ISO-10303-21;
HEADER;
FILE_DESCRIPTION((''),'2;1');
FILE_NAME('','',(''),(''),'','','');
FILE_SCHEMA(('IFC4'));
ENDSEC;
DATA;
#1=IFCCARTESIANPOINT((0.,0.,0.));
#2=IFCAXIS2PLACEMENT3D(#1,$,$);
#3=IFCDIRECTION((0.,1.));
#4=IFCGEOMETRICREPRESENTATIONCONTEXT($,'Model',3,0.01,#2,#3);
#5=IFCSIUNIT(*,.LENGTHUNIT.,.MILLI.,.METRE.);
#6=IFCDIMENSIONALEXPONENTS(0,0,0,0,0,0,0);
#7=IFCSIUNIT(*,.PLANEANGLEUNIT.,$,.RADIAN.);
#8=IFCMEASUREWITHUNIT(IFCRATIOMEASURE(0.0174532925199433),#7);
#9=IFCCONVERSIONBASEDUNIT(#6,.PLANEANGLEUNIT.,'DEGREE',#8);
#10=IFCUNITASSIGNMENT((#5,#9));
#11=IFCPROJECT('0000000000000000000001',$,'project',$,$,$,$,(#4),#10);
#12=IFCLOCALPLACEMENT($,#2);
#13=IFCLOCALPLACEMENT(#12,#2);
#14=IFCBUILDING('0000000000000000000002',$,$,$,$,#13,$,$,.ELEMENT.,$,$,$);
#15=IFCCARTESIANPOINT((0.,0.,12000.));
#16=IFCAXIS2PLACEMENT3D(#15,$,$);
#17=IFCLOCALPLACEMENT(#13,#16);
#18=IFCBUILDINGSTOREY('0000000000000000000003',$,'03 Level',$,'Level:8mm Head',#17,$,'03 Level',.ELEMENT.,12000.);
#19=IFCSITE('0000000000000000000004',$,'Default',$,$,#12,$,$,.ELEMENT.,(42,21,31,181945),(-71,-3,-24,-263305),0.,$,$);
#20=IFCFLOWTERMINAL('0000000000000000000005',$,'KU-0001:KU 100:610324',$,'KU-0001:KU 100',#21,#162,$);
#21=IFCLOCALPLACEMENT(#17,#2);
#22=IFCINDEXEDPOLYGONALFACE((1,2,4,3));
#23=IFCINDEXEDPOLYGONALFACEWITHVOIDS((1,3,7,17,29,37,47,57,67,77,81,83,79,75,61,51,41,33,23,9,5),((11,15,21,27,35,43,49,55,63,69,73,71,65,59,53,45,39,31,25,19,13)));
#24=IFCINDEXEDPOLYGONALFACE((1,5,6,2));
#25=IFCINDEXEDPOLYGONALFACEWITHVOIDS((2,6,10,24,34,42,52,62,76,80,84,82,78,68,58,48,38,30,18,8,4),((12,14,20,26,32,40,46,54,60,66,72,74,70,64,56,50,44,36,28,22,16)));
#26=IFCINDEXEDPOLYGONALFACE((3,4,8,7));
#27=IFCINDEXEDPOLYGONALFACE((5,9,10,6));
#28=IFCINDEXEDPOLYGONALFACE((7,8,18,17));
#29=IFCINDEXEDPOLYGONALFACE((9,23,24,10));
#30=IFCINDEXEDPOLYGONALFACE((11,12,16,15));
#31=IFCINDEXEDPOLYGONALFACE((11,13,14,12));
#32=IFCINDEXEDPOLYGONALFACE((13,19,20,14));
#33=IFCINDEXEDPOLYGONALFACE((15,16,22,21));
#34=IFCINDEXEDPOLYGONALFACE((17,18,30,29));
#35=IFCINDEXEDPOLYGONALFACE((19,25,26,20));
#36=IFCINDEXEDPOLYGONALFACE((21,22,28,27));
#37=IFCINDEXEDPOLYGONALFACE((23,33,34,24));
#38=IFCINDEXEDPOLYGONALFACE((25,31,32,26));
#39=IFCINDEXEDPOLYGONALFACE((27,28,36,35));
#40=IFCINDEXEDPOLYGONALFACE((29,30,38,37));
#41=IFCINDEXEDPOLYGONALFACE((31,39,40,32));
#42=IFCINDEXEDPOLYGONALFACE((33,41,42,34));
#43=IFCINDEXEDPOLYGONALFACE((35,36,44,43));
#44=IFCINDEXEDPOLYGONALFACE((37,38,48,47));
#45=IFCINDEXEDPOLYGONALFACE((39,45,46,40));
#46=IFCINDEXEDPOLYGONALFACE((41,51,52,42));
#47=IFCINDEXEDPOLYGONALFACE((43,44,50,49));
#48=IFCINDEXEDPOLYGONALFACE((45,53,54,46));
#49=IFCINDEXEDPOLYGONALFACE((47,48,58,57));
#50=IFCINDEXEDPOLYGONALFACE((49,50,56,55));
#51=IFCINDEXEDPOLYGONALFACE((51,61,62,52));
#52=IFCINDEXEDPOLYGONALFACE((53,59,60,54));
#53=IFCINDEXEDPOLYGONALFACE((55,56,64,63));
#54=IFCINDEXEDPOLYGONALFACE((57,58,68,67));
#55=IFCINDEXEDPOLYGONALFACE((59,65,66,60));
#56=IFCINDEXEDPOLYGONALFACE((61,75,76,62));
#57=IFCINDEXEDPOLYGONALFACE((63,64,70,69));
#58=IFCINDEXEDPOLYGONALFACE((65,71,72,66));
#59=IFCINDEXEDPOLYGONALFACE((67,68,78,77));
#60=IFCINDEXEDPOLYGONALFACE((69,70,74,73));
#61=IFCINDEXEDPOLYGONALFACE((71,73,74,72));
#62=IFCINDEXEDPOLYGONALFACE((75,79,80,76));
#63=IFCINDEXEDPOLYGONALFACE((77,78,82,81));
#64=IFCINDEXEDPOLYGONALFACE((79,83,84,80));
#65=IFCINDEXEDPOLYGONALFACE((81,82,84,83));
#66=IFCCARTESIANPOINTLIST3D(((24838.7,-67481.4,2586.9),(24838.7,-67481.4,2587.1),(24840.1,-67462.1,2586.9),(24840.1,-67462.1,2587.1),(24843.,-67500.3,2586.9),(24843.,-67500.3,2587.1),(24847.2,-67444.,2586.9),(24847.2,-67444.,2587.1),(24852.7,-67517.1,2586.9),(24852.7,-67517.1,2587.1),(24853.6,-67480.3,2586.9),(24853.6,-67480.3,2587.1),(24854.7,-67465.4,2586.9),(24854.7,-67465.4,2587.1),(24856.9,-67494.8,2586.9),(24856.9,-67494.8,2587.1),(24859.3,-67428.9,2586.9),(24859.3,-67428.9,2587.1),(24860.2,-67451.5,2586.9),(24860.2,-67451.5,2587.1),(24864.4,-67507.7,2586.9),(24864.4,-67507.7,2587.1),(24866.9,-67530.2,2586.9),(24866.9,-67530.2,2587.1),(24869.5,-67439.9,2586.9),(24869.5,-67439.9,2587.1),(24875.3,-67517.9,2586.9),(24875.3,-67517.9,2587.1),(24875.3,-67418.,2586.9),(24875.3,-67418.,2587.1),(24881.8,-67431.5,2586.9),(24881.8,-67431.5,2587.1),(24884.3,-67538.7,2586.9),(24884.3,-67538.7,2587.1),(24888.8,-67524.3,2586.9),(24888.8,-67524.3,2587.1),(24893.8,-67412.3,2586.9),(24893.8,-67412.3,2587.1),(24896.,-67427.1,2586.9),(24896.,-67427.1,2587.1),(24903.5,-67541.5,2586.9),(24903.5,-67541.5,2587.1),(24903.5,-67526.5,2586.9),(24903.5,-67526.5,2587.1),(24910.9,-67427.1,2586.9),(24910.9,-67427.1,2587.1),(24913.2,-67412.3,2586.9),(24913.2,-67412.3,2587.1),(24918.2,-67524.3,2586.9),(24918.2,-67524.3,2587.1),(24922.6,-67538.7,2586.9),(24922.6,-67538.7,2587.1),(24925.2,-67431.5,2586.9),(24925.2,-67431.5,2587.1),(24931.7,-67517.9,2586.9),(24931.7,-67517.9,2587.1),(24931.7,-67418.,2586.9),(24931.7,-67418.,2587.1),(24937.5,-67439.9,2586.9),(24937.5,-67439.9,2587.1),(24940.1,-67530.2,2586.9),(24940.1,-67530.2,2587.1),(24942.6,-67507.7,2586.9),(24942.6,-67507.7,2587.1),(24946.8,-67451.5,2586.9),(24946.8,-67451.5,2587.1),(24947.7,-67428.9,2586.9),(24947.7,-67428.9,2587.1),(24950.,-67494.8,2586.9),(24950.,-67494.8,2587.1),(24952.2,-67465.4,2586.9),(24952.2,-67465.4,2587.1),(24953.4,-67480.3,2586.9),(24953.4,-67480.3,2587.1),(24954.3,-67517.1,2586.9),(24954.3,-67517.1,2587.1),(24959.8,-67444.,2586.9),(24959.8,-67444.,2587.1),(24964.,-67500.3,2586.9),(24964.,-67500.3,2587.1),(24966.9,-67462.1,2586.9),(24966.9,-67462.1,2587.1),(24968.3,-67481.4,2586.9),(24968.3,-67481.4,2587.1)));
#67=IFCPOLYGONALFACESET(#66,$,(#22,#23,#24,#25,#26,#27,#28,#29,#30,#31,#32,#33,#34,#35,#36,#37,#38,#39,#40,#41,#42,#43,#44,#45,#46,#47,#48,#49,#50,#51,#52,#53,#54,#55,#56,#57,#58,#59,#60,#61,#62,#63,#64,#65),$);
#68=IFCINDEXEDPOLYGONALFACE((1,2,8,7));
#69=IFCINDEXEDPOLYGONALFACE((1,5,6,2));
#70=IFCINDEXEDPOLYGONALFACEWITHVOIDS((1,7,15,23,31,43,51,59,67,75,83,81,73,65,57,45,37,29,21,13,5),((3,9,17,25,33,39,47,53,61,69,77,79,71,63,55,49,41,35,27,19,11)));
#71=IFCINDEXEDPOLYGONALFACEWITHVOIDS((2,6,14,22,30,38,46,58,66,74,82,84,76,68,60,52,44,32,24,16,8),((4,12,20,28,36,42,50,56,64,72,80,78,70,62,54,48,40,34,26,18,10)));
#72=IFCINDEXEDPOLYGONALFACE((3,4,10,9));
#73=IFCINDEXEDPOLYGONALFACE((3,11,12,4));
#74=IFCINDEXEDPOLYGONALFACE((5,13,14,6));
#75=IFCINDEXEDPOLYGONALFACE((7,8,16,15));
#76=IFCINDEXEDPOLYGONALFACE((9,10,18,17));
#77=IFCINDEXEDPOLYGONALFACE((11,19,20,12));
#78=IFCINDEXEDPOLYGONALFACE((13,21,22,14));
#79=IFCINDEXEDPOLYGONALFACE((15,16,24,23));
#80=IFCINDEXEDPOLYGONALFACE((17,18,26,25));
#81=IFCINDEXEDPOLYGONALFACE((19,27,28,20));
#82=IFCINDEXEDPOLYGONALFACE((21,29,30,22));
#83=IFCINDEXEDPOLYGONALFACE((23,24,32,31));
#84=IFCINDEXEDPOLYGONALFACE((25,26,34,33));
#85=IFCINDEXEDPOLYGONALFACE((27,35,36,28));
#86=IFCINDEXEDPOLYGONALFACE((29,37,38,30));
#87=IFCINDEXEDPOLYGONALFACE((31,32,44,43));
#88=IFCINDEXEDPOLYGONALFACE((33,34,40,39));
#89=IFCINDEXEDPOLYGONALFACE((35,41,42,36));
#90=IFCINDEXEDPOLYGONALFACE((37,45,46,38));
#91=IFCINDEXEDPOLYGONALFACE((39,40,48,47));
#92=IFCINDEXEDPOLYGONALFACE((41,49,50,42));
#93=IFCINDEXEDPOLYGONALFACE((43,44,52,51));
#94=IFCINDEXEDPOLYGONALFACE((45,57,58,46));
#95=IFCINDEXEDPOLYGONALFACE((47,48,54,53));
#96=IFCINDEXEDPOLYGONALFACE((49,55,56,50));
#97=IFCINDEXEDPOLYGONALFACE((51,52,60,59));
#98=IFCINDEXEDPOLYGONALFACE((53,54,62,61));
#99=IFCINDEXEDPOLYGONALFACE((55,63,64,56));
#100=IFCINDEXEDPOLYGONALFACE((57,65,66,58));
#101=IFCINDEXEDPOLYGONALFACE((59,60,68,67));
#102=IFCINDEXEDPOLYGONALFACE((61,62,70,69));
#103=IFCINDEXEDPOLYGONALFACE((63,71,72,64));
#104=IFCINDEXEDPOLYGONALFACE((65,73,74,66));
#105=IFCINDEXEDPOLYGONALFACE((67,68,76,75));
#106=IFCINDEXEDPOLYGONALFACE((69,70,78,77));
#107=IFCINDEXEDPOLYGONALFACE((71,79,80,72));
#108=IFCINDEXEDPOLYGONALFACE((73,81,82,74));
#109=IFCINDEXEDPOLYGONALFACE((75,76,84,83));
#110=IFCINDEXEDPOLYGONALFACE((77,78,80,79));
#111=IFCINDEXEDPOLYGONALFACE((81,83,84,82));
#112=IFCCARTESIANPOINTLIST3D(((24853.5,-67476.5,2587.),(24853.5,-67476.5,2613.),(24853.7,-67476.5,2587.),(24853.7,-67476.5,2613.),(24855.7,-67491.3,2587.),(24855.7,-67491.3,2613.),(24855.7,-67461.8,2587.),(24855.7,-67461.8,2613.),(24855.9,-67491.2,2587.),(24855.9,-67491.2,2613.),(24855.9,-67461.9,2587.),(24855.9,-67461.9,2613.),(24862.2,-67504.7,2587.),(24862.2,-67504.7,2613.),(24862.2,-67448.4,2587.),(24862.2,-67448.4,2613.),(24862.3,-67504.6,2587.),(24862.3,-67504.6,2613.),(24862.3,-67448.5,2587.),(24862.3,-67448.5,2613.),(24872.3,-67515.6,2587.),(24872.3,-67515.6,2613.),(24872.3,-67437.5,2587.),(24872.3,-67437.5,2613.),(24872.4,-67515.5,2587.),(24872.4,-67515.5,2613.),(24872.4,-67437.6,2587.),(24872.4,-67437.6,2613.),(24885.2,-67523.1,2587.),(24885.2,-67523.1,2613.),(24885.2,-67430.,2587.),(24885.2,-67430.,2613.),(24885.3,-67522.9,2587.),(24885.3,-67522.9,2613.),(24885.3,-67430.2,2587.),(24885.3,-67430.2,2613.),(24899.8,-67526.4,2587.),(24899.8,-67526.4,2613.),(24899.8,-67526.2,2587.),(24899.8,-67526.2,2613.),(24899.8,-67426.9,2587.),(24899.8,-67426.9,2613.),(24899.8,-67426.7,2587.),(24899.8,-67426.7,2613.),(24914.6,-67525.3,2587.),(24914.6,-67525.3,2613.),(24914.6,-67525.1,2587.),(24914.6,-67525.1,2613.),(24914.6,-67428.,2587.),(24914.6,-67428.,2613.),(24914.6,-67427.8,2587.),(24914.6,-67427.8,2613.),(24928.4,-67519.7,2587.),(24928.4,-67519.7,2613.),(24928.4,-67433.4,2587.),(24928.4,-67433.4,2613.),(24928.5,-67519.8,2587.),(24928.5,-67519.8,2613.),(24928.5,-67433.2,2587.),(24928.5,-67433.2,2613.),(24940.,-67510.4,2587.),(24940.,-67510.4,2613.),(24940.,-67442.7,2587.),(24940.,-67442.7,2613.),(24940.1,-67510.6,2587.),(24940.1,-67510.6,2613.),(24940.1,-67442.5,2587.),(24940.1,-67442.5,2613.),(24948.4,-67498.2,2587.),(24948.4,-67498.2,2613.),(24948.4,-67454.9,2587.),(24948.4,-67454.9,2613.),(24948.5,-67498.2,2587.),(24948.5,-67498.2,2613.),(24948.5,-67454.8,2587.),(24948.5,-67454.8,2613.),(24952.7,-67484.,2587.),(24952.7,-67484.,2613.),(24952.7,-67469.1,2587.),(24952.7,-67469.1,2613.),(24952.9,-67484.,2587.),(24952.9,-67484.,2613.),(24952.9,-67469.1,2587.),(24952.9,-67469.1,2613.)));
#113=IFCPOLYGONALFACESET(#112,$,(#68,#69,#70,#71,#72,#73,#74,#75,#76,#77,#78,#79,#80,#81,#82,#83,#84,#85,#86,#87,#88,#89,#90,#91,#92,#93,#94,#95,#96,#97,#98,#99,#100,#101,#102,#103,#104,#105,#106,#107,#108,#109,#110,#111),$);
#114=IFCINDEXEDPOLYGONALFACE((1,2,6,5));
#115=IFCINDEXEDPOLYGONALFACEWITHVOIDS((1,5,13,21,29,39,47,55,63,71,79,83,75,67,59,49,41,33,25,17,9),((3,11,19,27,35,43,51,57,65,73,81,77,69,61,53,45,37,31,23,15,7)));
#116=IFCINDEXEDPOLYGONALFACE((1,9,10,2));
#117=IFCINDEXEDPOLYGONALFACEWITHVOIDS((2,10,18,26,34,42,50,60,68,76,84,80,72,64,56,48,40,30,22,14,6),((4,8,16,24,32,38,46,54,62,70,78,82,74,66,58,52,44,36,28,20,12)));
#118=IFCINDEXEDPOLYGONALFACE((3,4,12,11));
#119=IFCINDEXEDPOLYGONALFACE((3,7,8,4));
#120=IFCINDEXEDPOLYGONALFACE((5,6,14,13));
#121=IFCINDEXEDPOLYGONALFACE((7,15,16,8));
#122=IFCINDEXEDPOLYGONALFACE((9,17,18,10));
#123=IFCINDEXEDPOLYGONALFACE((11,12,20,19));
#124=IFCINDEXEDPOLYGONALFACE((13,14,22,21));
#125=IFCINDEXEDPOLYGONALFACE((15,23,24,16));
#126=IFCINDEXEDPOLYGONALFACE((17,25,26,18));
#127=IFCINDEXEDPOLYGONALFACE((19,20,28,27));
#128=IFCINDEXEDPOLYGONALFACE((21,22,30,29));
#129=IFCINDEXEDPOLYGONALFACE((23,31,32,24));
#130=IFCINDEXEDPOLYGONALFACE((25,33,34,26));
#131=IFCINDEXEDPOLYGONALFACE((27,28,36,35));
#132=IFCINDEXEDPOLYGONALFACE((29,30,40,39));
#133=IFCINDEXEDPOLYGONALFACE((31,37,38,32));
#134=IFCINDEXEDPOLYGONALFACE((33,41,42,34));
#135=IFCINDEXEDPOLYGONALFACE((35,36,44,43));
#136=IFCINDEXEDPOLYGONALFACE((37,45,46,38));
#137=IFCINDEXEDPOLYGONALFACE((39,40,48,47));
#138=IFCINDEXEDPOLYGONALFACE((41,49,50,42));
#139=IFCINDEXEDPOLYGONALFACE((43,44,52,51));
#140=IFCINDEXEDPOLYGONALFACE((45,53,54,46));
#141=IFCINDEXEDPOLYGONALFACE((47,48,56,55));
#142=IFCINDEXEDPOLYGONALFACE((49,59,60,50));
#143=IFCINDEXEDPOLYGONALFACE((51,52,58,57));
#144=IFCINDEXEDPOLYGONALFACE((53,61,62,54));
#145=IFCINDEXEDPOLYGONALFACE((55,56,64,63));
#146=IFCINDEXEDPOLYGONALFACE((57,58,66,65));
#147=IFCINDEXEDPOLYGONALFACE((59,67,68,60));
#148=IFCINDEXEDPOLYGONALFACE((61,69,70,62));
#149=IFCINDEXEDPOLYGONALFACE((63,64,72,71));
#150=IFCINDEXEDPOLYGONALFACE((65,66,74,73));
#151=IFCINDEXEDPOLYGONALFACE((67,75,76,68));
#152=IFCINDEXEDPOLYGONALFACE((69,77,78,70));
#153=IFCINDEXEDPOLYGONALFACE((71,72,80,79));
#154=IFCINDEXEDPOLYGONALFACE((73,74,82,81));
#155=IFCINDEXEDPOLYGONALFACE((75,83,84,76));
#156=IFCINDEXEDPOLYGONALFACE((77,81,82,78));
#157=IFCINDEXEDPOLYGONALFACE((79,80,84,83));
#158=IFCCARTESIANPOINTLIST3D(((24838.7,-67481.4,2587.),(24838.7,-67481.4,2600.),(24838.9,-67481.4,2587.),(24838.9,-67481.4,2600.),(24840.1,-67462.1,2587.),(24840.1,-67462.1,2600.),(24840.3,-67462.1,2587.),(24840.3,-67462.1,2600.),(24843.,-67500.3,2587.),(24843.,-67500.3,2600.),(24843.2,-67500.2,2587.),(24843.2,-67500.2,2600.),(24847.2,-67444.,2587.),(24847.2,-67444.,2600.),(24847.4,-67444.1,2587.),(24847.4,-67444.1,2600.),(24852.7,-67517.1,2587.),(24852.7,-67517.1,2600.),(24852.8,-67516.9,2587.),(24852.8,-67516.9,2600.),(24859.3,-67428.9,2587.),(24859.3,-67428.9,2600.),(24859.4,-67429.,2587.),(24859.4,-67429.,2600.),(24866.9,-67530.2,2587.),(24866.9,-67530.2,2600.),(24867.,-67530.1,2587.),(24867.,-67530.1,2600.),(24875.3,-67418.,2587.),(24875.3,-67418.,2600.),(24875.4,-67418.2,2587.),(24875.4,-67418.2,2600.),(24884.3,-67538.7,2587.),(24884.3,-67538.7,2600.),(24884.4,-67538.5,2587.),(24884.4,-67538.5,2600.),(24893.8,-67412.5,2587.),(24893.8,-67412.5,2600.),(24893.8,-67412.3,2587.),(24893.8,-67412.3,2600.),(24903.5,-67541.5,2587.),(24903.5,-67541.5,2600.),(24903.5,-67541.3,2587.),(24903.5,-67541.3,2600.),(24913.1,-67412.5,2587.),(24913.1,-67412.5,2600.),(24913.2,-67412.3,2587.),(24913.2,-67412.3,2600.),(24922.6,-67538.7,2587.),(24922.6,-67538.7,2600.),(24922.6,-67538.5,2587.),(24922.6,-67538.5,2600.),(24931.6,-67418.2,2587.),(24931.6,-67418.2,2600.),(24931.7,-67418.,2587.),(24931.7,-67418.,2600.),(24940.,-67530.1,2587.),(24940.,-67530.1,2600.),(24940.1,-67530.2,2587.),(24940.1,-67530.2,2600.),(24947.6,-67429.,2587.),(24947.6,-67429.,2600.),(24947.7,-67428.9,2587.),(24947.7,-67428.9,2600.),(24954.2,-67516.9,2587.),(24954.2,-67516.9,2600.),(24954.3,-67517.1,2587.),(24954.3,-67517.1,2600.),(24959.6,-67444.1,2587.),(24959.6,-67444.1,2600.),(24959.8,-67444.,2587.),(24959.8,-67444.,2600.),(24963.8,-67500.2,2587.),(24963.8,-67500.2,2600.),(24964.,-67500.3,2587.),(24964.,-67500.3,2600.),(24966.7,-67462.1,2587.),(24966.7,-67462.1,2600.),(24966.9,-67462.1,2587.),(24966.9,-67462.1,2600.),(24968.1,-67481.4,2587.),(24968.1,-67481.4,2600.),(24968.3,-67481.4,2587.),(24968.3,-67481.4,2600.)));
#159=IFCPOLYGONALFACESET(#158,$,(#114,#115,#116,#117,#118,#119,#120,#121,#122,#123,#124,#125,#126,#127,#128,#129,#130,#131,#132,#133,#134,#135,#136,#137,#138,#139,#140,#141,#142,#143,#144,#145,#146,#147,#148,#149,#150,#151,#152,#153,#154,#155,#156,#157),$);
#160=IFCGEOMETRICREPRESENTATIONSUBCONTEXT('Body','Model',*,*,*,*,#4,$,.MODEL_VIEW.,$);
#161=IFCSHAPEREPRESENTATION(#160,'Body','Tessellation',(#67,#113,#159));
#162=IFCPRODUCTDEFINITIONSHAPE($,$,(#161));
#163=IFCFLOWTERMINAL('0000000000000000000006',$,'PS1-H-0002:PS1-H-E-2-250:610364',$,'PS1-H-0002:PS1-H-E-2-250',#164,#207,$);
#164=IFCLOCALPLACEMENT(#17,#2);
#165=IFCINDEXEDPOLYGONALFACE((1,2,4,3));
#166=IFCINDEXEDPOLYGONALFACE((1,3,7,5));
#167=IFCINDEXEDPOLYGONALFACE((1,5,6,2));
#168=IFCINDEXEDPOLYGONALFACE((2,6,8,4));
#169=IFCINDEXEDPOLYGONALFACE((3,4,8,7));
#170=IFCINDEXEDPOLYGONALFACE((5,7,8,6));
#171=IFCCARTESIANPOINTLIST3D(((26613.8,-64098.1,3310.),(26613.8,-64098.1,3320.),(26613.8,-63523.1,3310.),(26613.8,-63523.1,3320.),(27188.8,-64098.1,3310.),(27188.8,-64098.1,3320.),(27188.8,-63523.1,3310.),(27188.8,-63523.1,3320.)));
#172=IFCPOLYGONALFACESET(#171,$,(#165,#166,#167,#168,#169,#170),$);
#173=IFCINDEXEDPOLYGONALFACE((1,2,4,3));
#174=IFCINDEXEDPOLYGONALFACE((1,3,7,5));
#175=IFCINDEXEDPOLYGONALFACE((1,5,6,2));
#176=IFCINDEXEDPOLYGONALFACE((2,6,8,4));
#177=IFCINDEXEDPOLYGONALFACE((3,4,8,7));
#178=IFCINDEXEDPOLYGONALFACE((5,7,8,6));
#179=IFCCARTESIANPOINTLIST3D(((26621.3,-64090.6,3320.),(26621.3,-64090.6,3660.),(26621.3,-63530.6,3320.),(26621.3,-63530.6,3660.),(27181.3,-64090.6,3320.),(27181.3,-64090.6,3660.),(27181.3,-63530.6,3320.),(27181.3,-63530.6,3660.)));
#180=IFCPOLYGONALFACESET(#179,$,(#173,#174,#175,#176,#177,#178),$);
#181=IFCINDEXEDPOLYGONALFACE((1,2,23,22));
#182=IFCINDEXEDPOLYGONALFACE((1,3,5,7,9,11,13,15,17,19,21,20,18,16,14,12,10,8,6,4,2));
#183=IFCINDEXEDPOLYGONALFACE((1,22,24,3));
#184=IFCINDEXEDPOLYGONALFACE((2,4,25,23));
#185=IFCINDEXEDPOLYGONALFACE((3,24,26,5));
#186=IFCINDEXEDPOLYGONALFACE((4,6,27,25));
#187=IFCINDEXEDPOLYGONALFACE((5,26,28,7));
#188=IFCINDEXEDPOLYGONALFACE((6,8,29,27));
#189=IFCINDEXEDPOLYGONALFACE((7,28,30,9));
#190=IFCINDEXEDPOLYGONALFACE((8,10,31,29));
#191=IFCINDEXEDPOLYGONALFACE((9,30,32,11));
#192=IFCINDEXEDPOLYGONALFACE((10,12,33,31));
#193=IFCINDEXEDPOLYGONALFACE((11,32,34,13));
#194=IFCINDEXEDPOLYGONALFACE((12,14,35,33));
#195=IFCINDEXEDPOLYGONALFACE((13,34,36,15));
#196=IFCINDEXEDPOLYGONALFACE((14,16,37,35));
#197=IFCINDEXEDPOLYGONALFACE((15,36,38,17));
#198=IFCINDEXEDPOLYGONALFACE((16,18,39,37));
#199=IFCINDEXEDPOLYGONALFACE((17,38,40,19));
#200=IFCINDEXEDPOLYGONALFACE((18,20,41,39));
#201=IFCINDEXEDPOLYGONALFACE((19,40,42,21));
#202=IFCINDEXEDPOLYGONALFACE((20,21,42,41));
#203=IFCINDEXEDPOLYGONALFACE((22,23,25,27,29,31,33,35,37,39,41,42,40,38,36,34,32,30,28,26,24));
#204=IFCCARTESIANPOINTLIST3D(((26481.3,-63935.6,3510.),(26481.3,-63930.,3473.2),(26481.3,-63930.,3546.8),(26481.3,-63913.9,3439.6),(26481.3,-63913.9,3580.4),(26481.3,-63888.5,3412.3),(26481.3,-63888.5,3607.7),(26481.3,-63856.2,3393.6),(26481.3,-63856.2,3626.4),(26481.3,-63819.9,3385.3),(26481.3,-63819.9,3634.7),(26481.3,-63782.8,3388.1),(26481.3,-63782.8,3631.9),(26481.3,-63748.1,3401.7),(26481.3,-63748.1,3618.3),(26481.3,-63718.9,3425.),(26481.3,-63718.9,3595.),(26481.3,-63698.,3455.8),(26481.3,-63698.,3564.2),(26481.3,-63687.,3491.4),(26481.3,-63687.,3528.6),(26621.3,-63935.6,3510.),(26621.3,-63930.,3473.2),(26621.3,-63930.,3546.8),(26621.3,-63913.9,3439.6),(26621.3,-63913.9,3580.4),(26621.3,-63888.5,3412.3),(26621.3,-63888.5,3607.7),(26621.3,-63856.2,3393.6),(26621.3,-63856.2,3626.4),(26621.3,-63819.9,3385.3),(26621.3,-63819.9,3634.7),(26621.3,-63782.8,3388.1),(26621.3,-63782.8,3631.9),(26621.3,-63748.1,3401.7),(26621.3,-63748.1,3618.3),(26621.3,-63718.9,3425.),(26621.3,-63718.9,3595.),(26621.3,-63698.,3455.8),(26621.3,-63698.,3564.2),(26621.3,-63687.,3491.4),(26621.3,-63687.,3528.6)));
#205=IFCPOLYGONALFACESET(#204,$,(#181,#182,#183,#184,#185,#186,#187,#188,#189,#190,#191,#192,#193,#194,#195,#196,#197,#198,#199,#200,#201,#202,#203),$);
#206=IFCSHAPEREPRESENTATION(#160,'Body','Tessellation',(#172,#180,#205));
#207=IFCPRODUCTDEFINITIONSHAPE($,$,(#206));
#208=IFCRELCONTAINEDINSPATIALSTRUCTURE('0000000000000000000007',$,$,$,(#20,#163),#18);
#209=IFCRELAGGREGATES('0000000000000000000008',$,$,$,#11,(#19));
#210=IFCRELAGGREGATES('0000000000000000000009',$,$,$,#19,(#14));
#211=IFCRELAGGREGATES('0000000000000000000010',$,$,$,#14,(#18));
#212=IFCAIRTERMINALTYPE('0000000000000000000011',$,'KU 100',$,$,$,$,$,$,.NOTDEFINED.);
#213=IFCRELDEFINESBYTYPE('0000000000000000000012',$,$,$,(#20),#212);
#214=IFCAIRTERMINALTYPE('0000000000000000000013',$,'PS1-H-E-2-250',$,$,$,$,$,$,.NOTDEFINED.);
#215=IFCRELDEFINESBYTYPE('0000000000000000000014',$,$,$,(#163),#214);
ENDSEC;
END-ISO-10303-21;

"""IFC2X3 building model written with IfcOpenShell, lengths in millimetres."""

from ifc_helpers import new_model, entity, si_unit, converted_unit, direction, frame, frame_2d, origin, origin_2d_with_axis, place, context, subcontext, project, spatial, rectangle, circle, hollow_circle, extrude, source, transform, mapped, type_object, type_shapes, element, save


model = new_model("IFC2X3")

# Units and contexts
model_context = context("Model", 3, precision=0.01, world=origin(), true_north=direction((0.0, 1.0)))
body_context = subcontext(model_context, "Body", "Model", "MODEL_VIEW")
ifc_project = project(units=[si_unit("LENGTHUNIT", "METRE", prefix="MILLI"), converted_unit("PLANEANGLEUNIT", "DEGREE", entity("IfcRatioMeasure", 0.0174532925199433), si_unit("PLANEANGLEUNIT", "RADIAN"), dimensions=[0, 0, 0, 0, 0, 0, 0])], contexts=[model_context])

# Site, building, storey
site_placement = place(None, origin())
site = spatial("IfcSite", under=ifc_project, at=site_placement, Name="Default", CompositionType="ELEMENT", RefLatitude=(42, 21, 31, 181945), RefLongitude=(-71, -3, -24, -263305), RefElevation=0.0)
building_placement = place(site_placement, origin())
building = spatial("IfcBuilding", under=site, at=building_placement, CompositionType="ELEMENT")
storey_placement = place(building_placement, frame((0.0, 0.0, 12000.0)))
storey = spatial("IfcBuildingStorey", under=building, at=storey_placement, Name="03 Level", ObjectType="Level:8mm Head", LongName="03 Level", CompositionType="ELEMENT", Elevation=12000.0)

# Flow terminals
air_terminal_type_1 = type_object("IfcAirTerminalType", Name="KU 100", PredefinedType="NOTDEFINED")
shared_shape_1 = source(origin(), body_context, "Body", "SweptSolid", [
    extrude(hollow_circle(Radius=65.0, WallThickness=15.0, at=frame_2d((0.0, 0.0), x_axis=(1.0, 0.0))), frame((12.9, 0.0, 0.0), z_axis=(1.0, 0.0, 0.0), x_axis=(0.0, -1.0, 0.0)), (0.0, 0.0, 1.0), 0.2),
    extrude(hollow_circle(Radius=50.0, WallThickness=0.2, at=frame_2d((0.0, 0.0), x_axis=(1.0, 0.0))), frame((-13.0, 0.0, 0.0), z_axis=(1.0, 0.0, 0.0), x_axis=(0.0, 0.0, -1.0)), (0.0, 0.0, 1.0), 26.0),
    extrude(hollow_circle(Radius=65.0, WallThickness=0.2, at=frame_2d((0.0, 0.0), x_axis=(1.0, 0.0))), frame((0.0, 0.0, 0.0), z_axis=(1.0, 0.0, 0.0), x_axis=(0.0, -1.0, 0.0)), (0.0, 0.0, 1.0), 13.0),
])
type_shapes(air_terminal_type_1, [shared_shape_1])
flow_terminal_1_placement = place(storey_placement, frame((24903.5, -67476.5, 2600.0), z_axis=(1.0, 0.0, 0.0), x_axis=(0.0, 0.0, -1.0)))
element("IfcFlowTerminal", 1, at=flow_terminal_1_placement, inside=storey, type_object=air_terminal_type_1, Name="KU-0001:KU 100:610324", ObjectType="KU-0001:KU 100", context=body_context, shape_type="MappedRepresentation", body=[
    mapped(shared_shape_1, transform((0.0, 0.0, 0.0), scale=1.0)),
])
air_terminal_type_2 = type_object("IfcAirTerminalType", Name="PS1-H-E-2-250", PredefinedType="NOTDEFINED")
shared_shape_2 = source(origin(), body_context, "Body", "SweptSolid", [
    extrude(rectangle(XDim=575.0, YDim=575.0, at=origin_2d_with_axis()), frame((0.0, 0.0, -10.0), z_axis=(0.0, 0.0, 1.0), x_axis=(0.0, 1.0, 0.0)), (0.0, 0.0, 1.0), 10.0),
    extrude(rectangle(XDim=560.0, YDim=560.0, at=origin_2d_with_axis()), frame((0.0, 0.0, 0.0), z_axis=(0.0, 0.0, 1.0), x_axis=(0.0, 1.0, 0.0)), (0.0, 0.0, 1.0), 340.0),
    extrude(circle(Radius=125.0, at=frame_2d((0.0, 0.0), x_axis=(1.0, 0.0))), frame((-420.0, 0.0, 190.0), z_axis=(1.0, 0.0, 0.0), x_axis=(0.0, -1.0, 0.0)), (0.0, 0.0, 1.0), 140.0),
])
type_shapes(air_terminal_type_2, [shared_shape_2])
flow_terminal_2_placement = place(storey_placement, frame((26901.3, -63810.6, 3320.0)))
element("IfcFlowTerminal", 2, at=flow_terminal_2_placement, inside=storey, type_object=air_terminal_type_2, Name="PS1-H-0002:PS1-H-E-2-250:610364", ObjectType="PS1-H-0002:PS1-H-E-2-250", context=body_context, shape_type="MappedRepresentation", body=[
    mapped(shared_shape_2, transform((0.0, 0.0, 0.0), scale=1.0)),
])

save(model, "model.ifc")
